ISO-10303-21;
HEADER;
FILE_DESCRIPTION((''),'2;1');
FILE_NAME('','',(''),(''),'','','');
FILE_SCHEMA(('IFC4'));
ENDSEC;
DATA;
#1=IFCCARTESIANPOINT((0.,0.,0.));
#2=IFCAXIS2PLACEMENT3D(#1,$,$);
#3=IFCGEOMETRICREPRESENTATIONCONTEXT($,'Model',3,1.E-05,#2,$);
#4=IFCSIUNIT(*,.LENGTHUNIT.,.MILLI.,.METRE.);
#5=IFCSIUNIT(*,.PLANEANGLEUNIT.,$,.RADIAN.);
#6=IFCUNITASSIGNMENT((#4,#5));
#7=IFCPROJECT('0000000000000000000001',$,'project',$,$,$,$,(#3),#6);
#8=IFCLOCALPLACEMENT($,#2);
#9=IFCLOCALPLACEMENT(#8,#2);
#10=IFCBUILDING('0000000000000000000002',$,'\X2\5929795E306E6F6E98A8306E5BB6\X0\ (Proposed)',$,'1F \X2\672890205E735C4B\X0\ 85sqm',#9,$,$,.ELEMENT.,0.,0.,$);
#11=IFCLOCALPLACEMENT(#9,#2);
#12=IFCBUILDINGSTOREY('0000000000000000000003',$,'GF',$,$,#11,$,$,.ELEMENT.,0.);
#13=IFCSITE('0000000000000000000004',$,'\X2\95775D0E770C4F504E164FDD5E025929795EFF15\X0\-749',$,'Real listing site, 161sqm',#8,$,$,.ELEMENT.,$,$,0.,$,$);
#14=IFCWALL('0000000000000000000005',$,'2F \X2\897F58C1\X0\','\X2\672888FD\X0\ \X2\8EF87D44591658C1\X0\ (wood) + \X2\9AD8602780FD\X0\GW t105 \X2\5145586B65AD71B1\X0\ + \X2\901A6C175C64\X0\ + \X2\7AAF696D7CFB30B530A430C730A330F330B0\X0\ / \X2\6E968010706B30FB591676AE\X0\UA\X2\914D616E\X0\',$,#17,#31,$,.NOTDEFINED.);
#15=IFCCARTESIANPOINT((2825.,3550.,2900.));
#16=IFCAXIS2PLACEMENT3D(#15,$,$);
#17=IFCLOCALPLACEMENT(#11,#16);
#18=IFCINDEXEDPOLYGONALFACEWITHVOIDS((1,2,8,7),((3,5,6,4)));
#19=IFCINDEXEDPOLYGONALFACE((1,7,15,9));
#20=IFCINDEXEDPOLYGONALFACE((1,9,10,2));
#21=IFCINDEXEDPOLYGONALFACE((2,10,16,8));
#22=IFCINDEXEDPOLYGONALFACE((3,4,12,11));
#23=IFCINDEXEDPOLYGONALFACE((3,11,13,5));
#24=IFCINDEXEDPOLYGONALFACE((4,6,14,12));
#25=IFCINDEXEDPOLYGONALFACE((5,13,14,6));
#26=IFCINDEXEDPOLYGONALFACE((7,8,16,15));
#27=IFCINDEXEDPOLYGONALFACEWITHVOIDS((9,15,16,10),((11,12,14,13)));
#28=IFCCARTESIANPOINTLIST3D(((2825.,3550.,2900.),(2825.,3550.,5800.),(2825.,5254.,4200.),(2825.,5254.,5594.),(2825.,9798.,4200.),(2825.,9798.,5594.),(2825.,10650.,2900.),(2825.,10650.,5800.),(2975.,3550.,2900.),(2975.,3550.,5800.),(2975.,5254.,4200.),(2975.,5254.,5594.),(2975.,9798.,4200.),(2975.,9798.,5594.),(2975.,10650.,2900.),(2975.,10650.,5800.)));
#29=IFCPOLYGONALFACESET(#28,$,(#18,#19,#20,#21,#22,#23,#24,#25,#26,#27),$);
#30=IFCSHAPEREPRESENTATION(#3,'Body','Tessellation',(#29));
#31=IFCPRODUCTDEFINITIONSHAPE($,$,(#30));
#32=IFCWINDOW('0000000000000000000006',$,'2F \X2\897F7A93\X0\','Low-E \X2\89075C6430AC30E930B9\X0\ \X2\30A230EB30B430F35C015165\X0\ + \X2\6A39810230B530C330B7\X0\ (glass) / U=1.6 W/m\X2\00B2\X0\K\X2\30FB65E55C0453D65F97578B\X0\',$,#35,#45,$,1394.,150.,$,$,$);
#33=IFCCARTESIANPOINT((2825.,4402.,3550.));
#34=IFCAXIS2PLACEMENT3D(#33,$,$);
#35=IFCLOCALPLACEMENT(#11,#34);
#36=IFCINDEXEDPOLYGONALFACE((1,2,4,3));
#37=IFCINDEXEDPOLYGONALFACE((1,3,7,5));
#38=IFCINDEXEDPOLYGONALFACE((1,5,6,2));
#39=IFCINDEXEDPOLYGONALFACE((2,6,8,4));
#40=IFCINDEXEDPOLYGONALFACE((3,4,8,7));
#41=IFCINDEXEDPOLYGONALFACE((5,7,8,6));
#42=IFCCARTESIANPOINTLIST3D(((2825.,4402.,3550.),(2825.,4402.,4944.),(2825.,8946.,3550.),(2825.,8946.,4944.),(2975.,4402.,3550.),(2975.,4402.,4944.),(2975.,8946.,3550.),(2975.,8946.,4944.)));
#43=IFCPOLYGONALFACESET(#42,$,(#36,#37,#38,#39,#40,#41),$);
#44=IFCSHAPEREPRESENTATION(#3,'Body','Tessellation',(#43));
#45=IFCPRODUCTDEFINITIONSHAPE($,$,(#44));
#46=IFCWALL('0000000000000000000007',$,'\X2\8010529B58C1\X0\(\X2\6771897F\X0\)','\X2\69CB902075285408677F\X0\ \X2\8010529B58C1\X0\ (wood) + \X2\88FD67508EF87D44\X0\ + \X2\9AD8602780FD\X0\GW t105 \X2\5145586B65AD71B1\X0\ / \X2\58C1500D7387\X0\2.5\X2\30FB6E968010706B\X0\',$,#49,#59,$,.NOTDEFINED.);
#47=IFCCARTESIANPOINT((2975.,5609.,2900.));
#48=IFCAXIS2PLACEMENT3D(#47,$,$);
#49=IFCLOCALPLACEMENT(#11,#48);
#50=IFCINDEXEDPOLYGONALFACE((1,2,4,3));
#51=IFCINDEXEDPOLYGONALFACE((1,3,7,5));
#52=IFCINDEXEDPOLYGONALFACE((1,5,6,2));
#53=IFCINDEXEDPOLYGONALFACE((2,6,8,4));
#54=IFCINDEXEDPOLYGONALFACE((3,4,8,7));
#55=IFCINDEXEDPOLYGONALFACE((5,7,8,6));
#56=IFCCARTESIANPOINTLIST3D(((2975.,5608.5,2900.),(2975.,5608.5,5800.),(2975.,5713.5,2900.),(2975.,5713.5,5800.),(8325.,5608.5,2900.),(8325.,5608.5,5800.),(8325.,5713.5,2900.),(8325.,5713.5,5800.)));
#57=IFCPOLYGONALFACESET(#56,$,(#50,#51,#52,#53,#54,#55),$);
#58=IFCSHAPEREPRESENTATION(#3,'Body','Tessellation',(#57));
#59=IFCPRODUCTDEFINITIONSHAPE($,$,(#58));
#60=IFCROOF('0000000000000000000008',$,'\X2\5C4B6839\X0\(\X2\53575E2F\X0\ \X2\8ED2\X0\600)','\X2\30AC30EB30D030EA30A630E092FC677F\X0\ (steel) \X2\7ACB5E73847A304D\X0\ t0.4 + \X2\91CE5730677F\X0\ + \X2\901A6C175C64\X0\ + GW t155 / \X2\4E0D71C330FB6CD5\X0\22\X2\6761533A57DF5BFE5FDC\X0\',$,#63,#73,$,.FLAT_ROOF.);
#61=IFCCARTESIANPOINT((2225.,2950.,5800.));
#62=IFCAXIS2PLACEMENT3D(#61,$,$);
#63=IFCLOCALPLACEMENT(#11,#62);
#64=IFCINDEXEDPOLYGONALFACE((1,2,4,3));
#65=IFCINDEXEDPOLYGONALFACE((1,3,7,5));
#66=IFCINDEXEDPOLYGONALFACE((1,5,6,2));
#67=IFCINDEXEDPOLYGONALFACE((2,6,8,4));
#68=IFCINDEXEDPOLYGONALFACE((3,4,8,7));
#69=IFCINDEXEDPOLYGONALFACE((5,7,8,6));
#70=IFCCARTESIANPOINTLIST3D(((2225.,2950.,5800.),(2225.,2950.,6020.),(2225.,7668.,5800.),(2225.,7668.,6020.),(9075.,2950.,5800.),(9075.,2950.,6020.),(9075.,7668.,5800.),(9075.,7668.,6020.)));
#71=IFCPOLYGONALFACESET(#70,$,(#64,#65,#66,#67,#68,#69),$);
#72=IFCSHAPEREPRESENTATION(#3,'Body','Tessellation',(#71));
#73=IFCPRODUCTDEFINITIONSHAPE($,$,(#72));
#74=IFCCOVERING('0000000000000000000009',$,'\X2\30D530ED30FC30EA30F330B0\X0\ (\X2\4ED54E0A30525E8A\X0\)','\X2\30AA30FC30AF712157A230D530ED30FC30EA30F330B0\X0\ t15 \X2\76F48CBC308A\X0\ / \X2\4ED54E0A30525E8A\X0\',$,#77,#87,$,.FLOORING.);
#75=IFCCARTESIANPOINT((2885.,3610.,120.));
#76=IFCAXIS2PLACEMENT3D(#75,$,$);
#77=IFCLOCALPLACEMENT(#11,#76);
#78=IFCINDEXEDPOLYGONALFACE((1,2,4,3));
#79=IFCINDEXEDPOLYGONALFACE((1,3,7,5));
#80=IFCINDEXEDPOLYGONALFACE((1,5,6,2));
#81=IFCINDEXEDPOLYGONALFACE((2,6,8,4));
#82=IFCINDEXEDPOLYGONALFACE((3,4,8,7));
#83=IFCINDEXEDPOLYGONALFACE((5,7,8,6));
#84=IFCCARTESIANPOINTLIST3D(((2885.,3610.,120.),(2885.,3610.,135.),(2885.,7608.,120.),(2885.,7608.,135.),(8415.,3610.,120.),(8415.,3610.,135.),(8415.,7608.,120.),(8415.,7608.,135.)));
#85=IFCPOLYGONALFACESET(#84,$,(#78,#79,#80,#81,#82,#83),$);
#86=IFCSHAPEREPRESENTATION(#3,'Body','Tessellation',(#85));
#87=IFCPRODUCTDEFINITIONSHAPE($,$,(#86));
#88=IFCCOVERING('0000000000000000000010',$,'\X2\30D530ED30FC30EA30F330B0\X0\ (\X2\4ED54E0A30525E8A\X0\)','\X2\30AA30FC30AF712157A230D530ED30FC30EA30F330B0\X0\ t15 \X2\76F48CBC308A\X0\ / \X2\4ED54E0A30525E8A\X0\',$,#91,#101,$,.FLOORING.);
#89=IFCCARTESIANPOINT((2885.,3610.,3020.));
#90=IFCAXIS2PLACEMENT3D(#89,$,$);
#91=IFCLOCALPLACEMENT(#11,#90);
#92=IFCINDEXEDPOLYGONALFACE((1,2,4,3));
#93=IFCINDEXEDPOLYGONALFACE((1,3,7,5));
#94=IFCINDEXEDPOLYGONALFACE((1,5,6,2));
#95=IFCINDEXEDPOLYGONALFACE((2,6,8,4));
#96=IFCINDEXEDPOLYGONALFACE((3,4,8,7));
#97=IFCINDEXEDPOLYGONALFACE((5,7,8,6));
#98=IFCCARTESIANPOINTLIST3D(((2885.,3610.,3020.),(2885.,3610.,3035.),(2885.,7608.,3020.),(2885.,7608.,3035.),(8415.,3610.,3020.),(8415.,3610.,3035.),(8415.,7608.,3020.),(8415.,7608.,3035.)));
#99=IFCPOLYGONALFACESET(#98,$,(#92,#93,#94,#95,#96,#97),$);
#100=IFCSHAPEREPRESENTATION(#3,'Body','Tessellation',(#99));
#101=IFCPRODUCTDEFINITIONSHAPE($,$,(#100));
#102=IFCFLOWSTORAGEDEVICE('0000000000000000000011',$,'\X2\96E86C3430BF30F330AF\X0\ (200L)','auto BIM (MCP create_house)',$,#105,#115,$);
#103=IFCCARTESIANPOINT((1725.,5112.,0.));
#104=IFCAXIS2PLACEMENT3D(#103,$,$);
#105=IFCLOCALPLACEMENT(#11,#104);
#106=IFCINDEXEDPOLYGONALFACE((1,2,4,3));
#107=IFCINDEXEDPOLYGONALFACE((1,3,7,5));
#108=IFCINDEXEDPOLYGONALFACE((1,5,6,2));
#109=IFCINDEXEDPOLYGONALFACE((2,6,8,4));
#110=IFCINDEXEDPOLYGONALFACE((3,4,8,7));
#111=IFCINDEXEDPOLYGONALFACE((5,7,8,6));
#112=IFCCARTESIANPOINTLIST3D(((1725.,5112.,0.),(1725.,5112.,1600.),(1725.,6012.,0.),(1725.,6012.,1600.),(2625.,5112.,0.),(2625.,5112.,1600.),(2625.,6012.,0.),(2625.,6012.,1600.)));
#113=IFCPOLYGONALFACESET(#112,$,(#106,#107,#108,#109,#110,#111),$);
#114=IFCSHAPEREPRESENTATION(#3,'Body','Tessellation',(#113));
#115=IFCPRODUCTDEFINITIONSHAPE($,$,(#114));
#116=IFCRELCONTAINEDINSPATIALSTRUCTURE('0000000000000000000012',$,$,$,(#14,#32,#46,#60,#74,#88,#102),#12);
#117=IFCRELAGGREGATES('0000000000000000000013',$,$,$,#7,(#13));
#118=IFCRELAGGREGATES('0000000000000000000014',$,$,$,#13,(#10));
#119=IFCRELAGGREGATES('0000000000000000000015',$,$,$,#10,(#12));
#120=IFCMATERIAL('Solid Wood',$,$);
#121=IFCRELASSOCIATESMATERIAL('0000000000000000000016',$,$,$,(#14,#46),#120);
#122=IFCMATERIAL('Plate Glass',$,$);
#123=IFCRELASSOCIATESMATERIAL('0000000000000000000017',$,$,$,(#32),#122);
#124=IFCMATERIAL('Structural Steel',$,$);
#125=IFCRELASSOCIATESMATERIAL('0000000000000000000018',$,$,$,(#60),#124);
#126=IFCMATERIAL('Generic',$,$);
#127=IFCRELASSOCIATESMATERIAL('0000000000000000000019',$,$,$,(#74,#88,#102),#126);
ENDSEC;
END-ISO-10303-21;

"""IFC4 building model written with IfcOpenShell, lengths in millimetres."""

from ifc_helpers import new_model, si_unit, frame, frame_2d, origin, place, context, project, spatial, rectangle, extrude, material, element, fill, save


model = new_model("IFC4")

# Units and contexts
model_context = context("Model", 3, precision=1e-05, world=origin())
ifc_project = project(units=[si_unit("LENGTHUNIT", "METRE", prefix="MILLI"), si_unit("PLANEANGLEUNIT", "RADIAN")], contexts=[model_context])

# Site, building, storey
site_placement = place(None, origin())
site = spatial("IfcSite", under=ifc_project, at=site_placement, Name="長崎県佐世保市天神５-749", ObjectType="Real listing site, 161sqm", CompositionType="ELEMENT", RefElevation=0.0)
building_placement = place(site_placement, origin())
building = spatial("IfcBuilding", under=site, at=building_placement, Name="天神の潮風の家 (Proposed)", ObjectType="1F 木造平屋 85sqm", CompositionType="ELEMENT", ElevationOfRefHeight=0.0, ElevationOfTerrain=0.0)
storey_placement = place(building_placement, origin())
storey = spatial("IfcBuildingStorey", under=building, at=storey_placement, Name="GF", CompositionType="ELEMENT", Elevation=0.0)

# Shared definitions
ifc_material_1 = material(Name="Solid Wood")
ifc_material_2 = material(Name="Generic")

# Shared definitions
ifc_material_3 = material(Name="Plate Glass")

# Wall, opening, window
wall_1_placement = place(storey_placement, frame((2825.0, 3550.0, 2900.0)))
wall_1 = element("IfcWall", 1, at=wall_1_placement, inside=storey, material=ifc_material_1, Name="2F 西壁", Description="木製 軸組外壁 (wood) + 高性能GW t105 充填断熱 + 通気層 + 窯業系サイディング / 準耐火・外皮UA配慮", PredefinedType="NOTDEFINED", context=model_context, shape_type="SweptSolid", body=[
    extrude(rectangle(XDim=150.0, YDim=7100.0, at=frame_2d((75.0, 3550.0))), frame((2825.0, 3550.0, 2900.0)), (0.0, 0.0, 1.0), 2900.0),
])
opening_1_placement = place(storey_placement, frame((2825.0, 4402.0, 3550.0)))
opening_1 = element("IfcOpeningElement", 2, at=opening_1_placement, cuts=wall_1, PredefinedType="NOTDEFINED", context=model_context, shape_type="SweptSolid", body=[
    extrude(rectangle(XDim=150.0, YDim=4544.0, at=frame_2d((75.0, 2272.0))), frame((2825.0, 4402.0, 3550.0)), (0.0, 0.0, 1.0), 1394.0),
])
window_1_placement = place(storey_placement, frame((2825.0, 4402.0, 3550.0)))
window_1 = element("IfcWindow", 3, at=window_1_placement, inside=storey, material=ifc_material_3, Name="2F 西窓", Description="Low-E 複層ガラス アルゴン封入 + 樹脂サッシ (glass) / U=1.6 W/m²K・日射取得型", OverallHeight=1394.0, OverallWidth=150.0, context=model_context, shape_type="SweptSolid", body=[
    extrude(rectangle(XDim=150.0, YDim=4544.0, at=frame_2d((75.0, 2272.0))), frame((2825.0, 4402.0, 3550.0)), (0.0, 0.0, 1.0), 1394.0),
])
fill(opening_1, window_1)

# Wall
wall_2_placement = place(storey_placement, frame((2975.0, 5609.0, 2900.0)))
element("IfcWall", 4, at=wall_2_placement, inside=storey, material=ifc_material_1, Name="耐力壁(東西)", Description="構造用合板 耐力壁 (wood) + 製材軸組 + 高性能GW t105 充填断熱 / 壁倍率2.5・準耐火", PredefinedType="NOTDEFINED", context=model_context, shape_type="SweptSolid", body=[
    extrude(rectangle(XDim=5350.0, YDim=105.0, at=frame_2d((2675.0, 52.0))), frame((2975.0, 5609.0, 2900.0)), (0.0, 0.0, 1.0), 2900.0),
])

# Roof
ifc_material_4 = material(Name="Structural Steel")
for number, where, name in (
    (5, (2225.0, 2950.0, 5800.0), "屋根(南帯 軒600)"),
):
    element("IfcRoof", number, at=place(storey_placement, frame(where)), inside=storey, material=ifc_material_4, Name=name, Description="ガルバリウム鋼板 (steel) 立平葺き t0.4 + 野地板 + 通気層 + GW t155 / 不燃・法22条区域対応", PredefinedType="FLAT_ROOF", context=model_context, shape_type="SweptSolid", body=[
        extrude(rectangle(XDim=6850.0, YDim=4718.0, at=frame_2d((3425.0, 2359.0))), frame((2225.0, 2950.0, 5800.0)), (0.0, 0.0, 1.0), 220.0),
    ])

# Coverings
covering_1_placement = place(storey_placement, frame((2885.0, 3610.0, 120.0)))
element("IfcCovering", 6, at=covering_1_placement, inside=storey, material=ifc_material_2, Name="フローリング (仕上げ床)", Description="オーク無垢フローリング t15 直貼り / 仕上げ床", PredefinedType="FLOORING", context=model_context, shape_type="SweptSolid", body=[
    extrude(rectangle(XDim=5530.0, YDim=3998.0, at=frame_2d((2765.0, 1999.0))), frame((2885.0, 3610.0, 120.0)), (0.0, 0.0, 1.0), 15.0),
])
covering_2_placement = place(storey_placement, frame((2885.0, 3610.0, 3020.0)))
element("IfcCovering", 7, at=covering_2_placement, inside=storey, material=ifc_material_2, Name="フローリング (仕上げ床)", Description="オーク無垢フローリング t15 直貼り / 仕上げ床", PredefinedType="FLOORING", context=model_context, shape_type="SweptSolid", body=[
    extrude(rectangle(XDim=5530.0, YDim=3998.0, at=frame_2d((2765.0, 1999.0))), frame((2885.0, 3610.0, 3020.0)), (0.0, 0.0, 1.0), 15.0),
])

# Flow storage device
flow_storage_device_placement = place(storey_placement, frame((1725.0, 5112.0, 0.0)))
element("IfcFlowStorageDevice", 8, at=flow_storage_device_placement, inside=storey, material=ifc_material_2, Name="雨水タンク (200L)", Description="auto BIM (MCP create_house)", context=model_context, shape_type="SweptSolid", body=[
    extrude(rectangle(XDim=900.0, YDim=900.0, at=frame_2d((450.0, 450.0))), frame((1725.0, 5112.0, 0.0)), (0.0, 0.0, 1.0), 1600.0),
])

save(model, "model.ifc")
